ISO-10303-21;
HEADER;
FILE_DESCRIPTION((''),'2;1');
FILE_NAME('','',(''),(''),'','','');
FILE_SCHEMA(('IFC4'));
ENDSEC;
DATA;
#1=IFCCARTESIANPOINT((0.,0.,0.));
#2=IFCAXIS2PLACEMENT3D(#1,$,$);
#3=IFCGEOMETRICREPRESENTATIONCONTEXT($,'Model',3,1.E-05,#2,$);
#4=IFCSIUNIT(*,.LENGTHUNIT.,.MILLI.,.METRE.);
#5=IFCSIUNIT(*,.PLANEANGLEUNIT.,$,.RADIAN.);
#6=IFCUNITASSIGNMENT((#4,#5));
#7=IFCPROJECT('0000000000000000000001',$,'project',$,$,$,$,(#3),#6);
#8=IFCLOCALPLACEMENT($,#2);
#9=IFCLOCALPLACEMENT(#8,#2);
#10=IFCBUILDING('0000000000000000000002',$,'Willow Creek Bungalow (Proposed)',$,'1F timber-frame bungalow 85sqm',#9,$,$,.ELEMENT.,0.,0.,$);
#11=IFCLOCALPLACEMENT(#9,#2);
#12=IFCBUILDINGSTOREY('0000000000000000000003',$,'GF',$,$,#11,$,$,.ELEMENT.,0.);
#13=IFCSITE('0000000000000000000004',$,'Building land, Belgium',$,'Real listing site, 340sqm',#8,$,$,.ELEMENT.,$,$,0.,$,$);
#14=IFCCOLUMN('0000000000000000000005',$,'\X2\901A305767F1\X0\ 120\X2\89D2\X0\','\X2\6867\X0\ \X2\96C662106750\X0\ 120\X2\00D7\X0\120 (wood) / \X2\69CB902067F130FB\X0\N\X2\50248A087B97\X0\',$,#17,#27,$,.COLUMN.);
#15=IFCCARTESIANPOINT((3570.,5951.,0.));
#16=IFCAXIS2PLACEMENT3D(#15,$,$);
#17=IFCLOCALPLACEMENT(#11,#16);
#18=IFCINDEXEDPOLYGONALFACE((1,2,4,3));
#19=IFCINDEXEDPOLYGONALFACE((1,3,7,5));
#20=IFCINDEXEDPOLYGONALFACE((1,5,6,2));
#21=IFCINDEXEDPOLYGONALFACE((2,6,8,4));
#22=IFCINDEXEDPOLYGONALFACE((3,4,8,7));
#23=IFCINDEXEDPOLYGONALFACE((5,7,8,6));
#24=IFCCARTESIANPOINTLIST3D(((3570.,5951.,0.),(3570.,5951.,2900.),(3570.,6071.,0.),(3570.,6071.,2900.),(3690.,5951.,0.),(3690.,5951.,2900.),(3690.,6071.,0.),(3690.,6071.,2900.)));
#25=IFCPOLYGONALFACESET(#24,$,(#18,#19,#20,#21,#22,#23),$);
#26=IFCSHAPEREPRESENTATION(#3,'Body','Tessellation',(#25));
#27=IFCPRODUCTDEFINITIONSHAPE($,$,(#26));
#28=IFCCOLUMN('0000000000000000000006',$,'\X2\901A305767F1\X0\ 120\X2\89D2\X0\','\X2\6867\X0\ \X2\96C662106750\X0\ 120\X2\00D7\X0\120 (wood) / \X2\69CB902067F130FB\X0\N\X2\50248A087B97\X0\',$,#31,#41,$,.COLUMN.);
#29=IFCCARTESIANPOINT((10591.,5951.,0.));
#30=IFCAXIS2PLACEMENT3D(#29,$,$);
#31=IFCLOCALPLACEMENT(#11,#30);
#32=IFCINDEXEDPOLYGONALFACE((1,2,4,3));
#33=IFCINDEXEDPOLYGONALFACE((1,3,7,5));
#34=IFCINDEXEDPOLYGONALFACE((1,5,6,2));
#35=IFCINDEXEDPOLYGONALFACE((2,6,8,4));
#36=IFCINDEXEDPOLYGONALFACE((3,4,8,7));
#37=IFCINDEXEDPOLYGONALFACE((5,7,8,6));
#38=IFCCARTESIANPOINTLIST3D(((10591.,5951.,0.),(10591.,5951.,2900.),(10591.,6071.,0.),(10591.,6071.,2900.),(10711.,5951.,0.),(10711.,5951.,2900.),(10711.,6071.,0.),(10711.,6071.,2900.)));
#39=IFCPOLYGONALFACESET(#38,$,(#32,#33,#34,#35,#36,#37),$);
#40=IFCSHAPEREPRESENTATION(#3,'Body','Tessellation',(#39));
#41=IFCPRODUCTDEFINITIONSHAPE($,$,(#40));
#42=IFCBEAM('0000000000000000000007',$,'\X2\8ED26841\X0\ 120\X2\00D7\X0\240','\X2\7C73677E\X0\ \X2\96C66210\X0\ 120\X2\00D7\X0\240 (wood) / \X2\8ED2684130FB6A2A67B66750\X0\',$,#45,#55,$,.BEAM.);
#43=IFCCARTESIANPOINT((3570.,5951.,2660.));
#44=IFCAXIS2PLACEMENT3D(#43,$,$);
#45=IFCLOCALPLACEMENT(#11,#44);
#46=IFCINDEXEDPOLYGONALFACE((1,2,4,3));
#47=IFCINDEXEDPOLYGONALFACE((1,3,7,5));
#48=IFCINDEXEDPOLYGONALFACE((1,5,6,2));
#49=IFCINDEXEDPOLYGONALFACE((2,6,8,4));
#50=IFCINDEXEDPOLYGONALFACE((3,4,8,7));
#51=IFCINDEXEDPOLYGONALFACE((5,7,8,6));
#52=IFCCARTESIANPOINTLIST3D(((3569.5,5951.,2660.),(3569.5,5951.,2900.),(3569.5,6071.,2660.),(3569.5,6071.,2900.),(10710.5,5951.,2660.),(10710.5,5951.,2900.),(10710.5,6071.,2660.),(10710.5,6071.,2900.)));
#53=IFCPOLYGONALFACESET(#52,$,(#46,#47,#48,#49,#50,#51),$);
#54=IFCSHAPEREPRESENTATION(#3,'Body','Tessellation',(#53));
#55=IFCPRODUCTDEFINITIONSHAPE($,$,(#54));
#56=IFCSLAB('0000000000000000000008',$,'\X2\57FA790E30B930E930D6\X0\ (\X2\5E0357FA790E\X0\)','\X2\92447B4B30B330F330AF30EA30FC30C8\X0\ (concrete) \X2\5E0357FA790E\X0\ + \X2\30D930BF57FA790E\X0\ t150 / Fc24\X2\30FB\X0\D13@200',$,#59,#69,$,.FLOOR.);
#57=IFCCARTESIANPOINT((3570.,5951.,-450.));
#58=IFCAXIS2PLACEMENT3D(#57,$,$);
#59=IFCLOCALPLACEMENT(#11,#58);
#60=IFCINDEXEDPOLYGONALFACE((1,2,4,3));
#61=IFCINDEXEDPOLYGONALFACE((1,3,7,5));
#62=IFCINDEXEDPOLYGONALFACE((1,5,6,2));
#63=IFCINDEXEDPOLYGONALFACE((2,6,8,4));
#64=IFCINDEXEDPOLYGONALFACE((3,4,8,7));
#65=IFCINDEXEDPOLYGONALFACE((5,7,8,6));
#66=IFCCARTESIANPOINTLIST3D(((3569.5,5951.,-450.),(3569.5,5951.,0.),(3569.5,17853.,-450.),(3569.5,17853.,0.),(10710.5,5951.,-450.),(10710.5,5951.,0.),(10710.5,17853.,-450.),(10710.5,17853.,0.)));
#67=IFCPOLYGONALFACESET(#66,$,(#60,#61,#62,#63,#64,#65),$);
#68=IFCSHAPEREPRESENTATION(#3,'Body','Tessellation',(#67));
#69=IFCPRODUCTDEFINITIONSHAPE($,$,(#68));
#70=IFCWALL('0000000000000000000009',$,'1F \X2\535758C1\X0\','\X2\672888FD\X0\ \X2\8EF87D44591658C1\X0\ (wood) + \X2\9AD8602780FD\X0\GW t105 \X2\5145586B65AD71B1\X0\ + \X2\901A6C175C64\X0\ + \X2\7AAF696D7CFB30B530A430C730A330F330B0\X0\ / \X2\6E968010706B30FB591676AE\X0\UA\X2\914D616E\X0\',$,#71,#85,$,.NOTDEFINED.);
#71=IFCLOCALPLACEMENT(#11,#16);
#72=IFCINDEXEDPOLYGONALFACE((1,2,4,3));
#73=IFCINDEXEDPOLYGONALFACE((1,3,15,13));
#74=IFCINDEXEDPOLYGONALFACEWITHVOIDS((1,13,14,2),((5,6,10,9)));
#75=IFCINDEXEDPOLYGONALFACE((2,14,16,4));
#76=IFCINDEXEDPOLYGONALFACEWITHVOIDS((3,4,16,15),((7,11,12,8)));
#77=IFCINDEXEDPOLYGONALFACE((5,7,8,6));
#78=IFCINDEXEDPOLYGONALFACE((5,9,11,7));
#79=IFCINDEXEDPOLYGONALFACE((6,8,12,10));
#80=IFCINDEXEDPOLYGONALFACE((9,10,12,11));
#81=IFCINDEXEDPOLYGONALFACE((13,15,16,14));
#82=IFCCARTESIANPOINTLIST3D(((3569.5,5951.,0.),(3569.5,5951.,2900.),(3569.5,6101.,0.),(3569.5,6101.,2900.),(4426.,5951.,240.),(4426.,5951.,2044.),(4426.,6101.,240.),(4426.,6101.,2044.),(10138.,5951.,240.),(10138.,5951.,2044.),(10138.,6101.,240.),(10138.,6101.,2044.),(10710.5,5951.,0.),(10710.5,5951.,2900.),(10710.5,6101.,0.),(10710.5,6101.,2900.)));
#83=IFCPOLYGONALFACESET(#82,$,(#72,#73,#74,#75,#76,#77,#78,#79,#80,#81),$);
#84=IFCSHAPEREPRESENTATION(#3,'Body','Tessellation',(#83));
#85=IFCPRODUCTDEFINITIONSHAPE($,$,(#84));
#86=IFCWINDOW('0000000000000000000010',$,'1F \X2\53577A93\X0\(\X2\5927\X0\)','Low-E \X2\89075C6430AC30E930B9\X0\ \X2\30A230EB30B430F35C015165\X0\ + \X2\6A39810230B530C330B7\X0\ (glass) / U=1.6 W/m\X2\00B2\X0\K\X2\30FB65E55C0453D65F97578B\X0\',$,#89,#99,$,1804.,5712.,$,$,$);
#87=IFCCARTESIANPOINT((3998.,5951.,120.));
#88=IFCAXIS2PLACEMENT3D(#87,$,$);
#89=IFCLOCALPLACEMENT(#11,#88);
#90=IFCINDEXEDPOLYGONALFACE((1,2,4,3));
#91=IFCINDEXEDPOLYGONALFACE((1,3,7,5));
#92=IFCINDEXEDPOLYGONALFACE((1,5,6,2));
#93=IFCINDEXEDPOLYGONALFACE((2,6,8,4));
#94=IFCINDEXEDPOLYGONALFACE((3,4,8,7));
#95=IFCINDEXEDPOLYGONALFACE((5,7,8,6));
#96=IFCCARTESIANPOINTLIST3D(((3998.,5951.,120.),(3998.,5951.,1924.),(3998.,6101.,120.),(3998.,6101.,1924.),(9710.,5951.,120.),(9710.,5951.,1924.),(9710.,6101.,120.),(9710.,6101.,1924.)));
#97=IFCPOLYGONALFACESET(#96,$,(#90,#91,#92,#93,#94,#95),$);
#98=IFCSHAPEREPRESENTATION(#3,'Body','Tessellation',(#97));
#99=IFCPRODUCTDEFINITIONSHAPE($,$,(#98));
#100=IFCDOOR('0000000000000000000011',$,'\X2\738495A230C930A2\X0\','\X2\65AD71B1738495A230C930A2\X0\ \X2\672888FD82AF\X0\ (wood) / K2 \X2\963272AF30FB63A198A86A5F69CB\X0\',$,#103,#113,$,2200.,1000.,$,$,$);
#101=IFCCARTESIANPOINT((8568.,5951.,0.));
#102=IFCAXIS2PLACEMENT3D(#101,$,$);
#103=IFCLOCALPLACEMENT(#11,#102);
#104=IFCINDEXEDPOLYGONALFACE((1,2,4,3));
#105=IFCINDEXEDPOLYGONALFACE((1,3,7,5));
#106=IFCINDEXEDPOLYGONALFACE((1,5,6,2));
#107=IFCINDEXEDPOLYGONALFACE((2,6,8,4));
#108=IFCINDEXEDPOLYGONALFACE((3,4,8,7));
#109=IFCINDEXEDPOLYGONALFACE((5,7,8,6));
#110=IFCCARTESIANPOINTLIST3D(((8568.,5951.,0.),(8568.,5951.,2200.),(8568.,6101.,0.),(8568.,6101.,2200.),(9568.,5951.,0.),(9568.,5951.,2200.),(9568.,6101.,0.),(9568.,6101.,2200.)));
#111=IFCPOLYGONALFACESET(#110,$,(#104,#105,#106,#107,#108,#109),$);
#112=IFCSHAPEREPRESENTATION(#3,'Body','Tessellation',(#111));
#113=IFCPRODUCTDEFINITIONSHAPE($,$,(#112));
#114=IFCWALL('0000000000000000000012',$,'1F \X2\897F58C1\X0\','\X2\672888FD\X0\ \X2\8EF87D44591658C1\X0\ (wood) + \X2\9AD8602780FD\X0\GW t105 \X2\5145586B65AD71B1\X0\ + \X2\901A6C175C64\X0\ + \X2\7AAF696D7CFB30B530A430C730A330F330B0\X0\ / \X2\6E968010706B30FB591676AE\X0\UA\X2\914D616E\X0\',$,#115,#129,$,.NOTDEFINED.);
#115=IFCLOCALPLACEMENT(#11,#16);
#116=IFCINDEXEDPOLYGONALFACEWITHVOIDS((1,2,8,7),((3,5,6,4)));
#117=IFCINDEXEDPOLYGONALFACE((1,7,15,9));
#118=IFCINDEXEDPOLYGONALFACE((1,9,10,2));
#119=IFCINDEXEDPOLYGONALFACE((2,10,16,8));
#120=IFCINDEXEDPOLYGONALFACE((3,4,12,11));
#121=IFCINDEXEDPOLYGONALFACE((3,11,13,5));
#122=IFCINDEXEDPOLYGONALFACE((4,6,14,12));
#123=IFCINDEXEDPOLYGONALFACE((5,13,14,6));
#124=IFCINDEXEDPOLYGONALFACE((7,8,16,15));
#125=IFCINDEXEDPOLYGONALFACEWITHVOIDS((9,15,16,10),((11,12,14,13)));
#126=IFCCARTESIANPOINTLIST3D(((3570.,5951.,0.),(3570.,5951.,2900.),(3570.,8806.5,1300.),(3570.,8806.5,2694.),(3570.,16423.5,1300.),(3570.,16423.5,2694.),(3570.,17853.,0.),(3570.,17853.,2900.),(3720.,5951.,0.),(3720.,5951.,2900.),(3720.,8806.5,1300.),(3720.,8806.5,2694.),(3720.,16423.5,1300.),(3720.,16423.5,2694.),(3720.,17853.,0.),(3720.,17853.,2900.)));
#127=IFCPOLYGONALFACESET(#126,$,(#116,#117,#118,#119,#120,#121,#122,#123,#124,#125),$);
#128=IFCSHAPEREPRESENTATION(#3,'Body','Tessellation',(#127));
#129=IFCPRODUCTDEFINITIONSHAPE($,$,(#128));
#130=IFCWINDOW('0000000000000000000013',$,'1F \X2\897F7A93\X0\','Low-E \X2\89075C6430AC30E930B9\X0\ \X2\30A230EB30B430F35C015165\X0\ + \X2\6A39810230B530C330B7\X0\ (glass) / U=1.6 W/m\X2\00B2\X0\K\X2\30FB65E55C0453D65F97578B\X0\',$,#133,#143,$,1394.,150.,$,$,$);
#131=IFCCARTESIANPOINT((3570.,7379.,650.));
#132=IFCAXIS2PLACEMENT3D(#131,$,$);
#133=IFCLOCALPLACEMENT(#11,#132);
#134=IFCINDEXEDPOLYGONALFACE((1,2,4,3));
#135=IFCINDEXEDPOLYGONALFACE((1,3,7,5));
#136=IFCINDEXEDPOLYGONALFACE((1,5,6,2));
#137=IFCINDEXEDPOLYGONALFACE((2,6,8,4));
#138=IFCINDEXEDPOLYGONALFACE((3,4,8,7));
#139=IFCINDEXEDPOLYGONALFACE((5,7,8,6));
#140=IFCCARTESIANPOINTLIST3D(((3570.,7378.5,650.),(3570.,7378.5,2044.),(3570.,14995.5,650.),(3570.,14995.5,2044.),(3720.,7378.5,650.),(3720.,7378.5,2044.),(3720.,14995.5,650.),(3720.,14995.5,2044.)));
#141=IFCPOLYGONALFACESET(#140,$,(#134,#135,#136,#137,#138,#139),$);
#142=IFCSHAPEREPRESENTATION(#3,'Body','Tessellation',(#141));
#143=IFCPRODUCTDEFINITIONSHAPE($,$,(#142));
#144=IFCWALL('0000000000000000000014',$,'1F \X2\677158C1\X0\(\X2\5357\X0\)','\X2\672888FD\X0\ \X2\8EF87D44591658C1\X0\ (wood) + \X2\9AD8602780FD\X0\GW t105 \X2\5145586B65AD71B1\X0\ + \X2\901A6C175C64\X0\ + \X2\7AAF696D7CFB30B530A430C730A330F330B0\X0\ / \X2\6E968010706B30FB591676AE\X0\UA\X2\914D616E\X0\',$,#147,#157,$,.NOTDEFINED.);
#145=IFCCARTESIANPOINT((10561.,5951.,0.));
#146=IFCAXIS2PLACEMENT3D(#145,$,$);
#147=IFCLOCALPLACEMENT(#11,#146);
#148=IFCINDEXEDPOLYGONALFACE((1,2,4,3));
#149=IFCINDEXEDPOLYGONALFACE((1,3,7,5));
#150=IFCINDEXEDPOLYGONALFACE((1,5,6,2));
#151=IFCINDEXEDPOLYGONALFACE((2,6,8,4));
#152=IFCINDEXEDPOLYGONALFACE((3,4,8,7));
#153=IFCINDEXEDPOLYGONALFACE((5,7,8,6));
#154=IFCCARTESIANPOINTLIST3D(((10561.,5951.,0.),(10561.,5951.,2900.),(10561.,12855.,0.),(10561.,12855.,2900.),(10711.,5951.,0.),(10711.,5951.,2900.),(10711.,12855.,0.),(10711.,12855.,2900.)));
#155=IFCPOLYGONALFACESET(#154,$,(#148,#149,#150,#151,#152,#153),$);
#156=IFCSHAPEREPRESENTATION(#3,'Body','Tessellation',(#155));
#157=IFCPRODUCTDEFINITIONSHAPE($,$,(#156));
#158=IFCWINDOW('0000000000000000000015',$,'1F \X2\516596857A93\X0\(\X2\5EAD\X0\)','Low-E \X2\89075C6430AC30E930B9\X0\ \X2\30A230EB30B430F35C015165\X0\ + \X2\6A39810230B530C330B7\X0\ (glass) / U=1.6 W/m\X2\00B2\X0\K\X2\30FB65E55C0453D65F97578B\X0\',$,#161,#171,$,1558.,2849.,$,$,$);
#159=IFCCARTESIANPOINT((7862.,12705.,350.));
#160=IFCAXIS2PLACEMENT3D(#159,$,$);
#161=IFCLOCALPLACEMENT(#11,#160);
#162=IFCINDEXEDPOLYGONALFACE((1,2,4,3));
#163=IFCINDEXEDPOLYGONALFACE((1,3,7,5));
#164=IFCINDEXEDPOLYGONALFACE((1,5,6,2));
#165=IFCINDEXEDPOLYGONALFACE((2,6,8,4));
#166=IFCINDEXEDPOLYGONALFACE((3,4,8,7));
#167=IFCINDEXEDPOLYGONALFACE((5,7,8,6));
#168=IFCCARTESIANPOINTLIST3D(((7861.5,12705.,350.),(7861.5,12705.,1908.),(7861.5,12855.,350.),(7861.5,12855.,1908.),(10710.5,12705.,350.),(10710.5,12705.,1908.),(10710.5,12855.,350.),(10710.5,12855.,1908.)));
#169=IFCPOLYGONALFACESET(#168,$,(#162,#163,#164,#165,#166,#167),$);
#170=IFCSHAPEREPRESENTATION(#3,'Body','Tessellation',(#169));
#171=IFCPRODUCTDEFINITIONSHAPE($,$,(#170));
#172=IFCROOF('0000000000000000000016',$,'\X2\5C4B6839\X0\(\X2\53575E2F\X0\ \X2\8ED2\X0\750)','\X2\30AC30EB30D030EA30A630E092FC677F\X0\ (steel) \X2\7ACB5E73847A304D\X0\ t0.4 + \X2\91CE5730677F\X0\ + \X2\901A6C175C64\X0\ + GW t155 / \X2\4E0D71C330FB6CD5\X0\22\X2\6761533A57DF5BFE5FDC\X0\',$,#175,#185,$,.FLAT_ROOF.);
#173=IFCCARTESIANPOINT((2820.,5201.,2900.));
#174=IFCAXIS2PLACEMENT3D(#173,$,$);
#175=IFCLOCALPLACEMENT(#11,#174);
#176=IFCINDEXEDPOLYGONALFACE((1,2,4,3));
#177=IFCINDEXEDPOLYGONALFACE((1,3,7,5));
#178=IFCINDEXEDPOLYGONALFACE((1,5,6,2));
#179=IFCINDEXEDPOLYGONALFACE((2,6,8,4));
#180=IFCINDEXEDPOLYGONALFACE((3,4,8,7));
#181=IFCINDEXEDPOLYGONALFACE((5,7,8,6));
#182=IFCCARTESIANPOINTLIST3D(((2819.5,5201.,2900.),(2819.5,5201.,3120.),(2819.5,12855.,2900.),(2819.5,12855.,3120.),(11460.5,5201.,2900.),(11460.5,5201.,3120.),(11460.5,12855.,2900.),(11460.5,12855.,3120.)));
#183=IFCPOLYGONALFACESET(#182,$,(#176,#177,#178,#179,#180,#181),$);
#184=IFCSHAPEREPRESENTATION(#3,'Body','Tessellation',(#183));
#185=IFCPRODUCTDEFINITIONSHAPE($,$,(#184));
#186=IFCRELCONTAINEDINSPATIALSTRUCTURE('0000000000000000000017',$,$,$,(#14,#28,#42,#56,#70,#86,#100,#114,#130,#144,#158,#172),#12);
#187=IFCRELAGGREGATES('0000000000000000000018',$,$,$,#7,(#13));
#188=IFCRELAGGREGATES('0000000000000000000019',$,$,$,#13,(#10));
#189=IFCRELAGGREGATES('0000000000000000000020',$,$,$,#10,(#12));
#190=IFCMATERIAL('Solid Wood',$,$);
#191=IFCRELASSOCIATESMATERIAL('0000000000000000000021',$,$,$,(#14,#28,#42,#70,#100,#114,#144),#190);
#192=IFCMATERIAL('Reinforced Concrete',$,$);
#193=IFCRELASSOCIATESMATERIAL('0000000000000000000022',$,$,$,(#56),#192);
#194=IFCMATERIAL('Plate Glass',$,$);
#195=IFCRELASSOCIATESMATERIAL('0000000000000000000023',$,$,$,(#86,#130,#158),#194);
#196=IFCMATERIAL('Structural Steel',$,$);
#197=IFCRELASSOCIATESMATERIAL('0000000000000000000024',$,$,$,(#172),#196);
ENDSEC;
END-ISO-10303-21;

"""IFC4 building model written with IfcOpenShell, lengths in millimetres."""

from ifc_helpers import new_model, si_unit, frame, frame_2d, origin, place, context, project, spatial, rectangle, extrude, material, element, fill, save


model = new_model("IFC4")

# Units and contexts
model_context = context("Model", 3, precision=1e-05, world=origin())
ifc_project = project(units=[si_unit("LENGTHUNIT", "METRE", prefix="MILLI"), si_unit("PLANEANGLEUNIT", "RADIAN")], contexts=[model_context])

# Site, building, storey
site_placement = place(None, origin())
site = spatial("IfcSite", under=ifc_project, at=site_placement, Name="Building land, Belgium", ObjectType="Real listing site, 340sqm", CompositionType="ELEMENT", RefElevation=0.0)
building_placement = place(site_placement, origin())
building = spatial("IfcBuilding", under=site, at=building_placement, Name="Willow Creek Bungalow (Proposed)", ObjectType="1F timber-frame bungalow 85sqm", CompositionType="ELEMENT", ElevationOfRefHeight=0.0, ElevationOfTerrain=0.0)
storey_placement = place(building_placement, origin())
storey = spatial("IfcBuildingStorey", under=building, at=storey_placement, Name="GF", CompositionType="ELEMENT", Elevation=0.0)

# Columns
ifc_material_1 = material(Name="Solid Wood")
column_1_placement = place(storey_placement, frame((3570.0, 5951.0, 0.0)))
element("IfcColumn", 1, at=column_1_placement, inside=storey, material=ifc_material_1, Name="通し柱 120角", Description="桧 集成材 120×120 (wood) / 構造柱・N値計算", PredefinedType="COLUMN", context=model_context, shape_type="SweptSolid", body=[
    extrude(rectangle(XDim=120.0, YDim=120.0, at=frame_2d((60.0, 60.0))), frame((3570.0, 5951.0, 0.0)), (0.0, 0.0, 1.0), 2900.0),
])
column_2_placement = place(storey_placement, frame((10591.0, 5951.0, 0.0)))
element("IfcColumn", 2, at=column_2_placement, inside=storey, material=ifc_material_1, Name="通し柱 120角", Description="桧 集成材 120×120 (wood) / 構造柱・N値計算", PredefinedType="COLUMN", context=model_context, shape_type="SweptSolid", body=[
    extrude(rectangle(XDim=120.0, YDim=120.0, at=frame_2d((60.0, 60.0))), frame((10591.0, 5951.0, 0.0)), (0.0, 0.0, 1.0), 2900.0),
])

# Beam
beam_1_placement = place(storey_placement, frame((3570.0, 5951.0, 2660.0)))
element("IfcBeam", 3, at=beam_1_placement, inside=storey, material=ifc_material_1, Name="軒桁 120×240", Description="米松 集成 120×240 (wood) / 軒桁・横架材", PredefinedType="BEAM", context=model_context, shape_type="SweptSolid", body=[
    extrude(rectangle(XDim=7141.0, YDim=120.0, at=frame_2d((3570.0, 60.0))), frame((3570.0, 5951.0, 2660.0)), (0.0, 0.0, 1.0), 240.0),
])

# Slab
ifc_material_2 = material(Name="Reinforced Concrete")
slab_1_placement = place(storey_placement, frame((3570.0, 5951.0, -450.0)))
element("IfcSlab", 4, at=slab_1_placement, inside=storey, material=ifc_material_2, Name="基礎スラブ (布基礎)", Description="鉄筋コンクリート (concrete) 布基礎 + ベタ基礎 t150 / Fc24・D13@200", PredefinedType="FLOOR", context=model_context, shape_type="SweptSolid", body=[
    extrude(rectangle(XDim=7141.0, YDim=11902.0, at=frame_2d((3570.0, 5951.0))), frame((3570.0, 5951.0, -450.0)), (0.0, 0.0, 1.0), 450.0),
])

# Wall, openings, window, door
wall_1_placement = place(storey_placement, frame((3570.0, 5951.0, 0.0)))
wall_1 = element("IfcWall", 5, at=wall_1_placement, inside=storey, material=ifc_material_1, Name="1F 南壁", Description="木製 軸組外壁 (wood) + 高性能GW t105 充填断熱 + 通気層 + 窯業系サイディング / 準耐火・外皮UA配慮", PredefinedType="NOTDEFINED", context=model_context, shape_type="SweptSolid", body=[
    extrude(rectangle(XDim=7141.0, YDim=150.0, at=frame_2d((3570.0, 75.0))), frame((3570.0, 5951.0, 0.0)), (0.0, 0.0, 1.0), 2900.0),
])
opening_1_placement = place(storey_placement, frame((3998.0, 5951.0, 120.0)))
opening_1 = element("IfcOpeningElement", 6, at=opening_1_placement, cuts=wall_1, PredefinedType="NOTDEFINED", context=model_context, shape_type="SweptSolid", body=[
    extrude(rectangle(XDim=5712.0, YDim=150.0, at=frame_2d((2856.0, 75.0))), frame((3998.0, 5951.0, 120.0)), (0.0, 0.0, 1.0), 1804.0),
])
opening_2_placement = place(storey_placement, frame((8568.0, 5951.0, 0.0)))
opening_2 = element("IfcOpeningElement", 7, at=opening_2_placement, cuts=wall_1, PredefinedType="NOTDEFINED", context=model_context, shape_type="SweptSolid", body=[
    extrude(rectangle(XDim=1000.0, YDim=150.0, at=frame_2d((500.0, 75.0))), frame((8568.0, 5951.0, 0.0)), (0.0, 0.0, 1.0), 2200.0),
])
ifc_material_3 = material(Name="Plate Glass")
window_1_placement = place(storey_placement, frame((3998.0, 5951.0, 120.0)))
window_1 = element("IfcWindow", 8, at=window_1_placement, inside=storey, material=ifc_material_3, Name="1F 南窓(大)", Description="Low-E 複層ガラス アルゴン封入 + 樹脂サッシ (glass) / U=1.6 W/m²K・日射取得型", OverallHeight=1804.0, OverallWidth=5712.0, context=model_context, shape_type="SweptSolid", body=[
    extrude(rectangle(XDim=5712.0, YDim=150.0, at=frame_2d((2856.0, 75.0))), frame((3998.0, 5951.0, 120.0)), (0.0, 0.0, 1.0), 1804.0),
])
fill(opening_1, window_1)
door_1_placement = place(storey_placement, frame((8568.0, 5951.0, 0.0)))
door_1 = element("IfcDoor", 9, at=door_1_placement, inside=storey, material=ifc_material_1, Name="玄関ドア", Description="断熱玄関ドア 木製芯 (wood) / K2 防犯・採風機構", OverallHeight=2200.0, OverallWidth=1000.0, context=model_context, shape_type="SweptSolid", body=[
    extrude(rectangle(XDim=1000.0, YDim=150.0, at=frame_2d((500.0, 75.0))), frame((8568.0, 5951.0, 0.0)), (0.0, 0.0, 1.0), 2200.0),
])
fill(opening_2, door_1)

# Walls, openings, windows
wall_2_placement = place(storey_placement, frame((3570.0, 5951.0, 0.0)))
wall_2 = element("IfcWall", 10, at=wall_2_placement, inside=storey, material=ifc_material_1, Name="1F 西壁", Description="木製 軸組外壁 (wood) + 高性能GW t105 充填断熱 + 通気層 + 窯業系サイディング / 準耐火・外皮UA配慮", PredefinedType="NOTDEFINED", context=model_context, shape_type="SweptSolid", body=[
    extrude(rectangle(XDim=150.0, YDim=11902.0, at=frame_2d((75.0, 5951.0))), frame((3570.0, 5951.0, 0.0)), (0.0, 0.0, 1.0), 2900.0),
])
opening_3_placement = place(storey_placement, frame((3570.0, 7379.0, 650.0)))
opening_3 = element("IfcOpeningElement", 11, at=opening_3_placement, cuts=wall_2, PredefinedType="NOTDEFINED", context=model_context, shape_type="SweptSolid", body=[
    extrude(rectangle(XDim=150.0, YDim=7617.0, at=frame_2d((75.0, 3808.0))), frame((3570.0, 7379.0, 650.0)), (0.0, 0.0, 1.0), 1394.0),
])
window_2_placement = place(storey_placement, frame((3570.0, 7379.0, 650.0)))
window_2 = element("IfcWindow", 12, at=window_2_placement, inside=storey, material=ifc_material_3, Name="1F 西窓", Description="Low-E 複層ガラス アルゴン封入 + 樹脂サッシ (glass) / U=1.6 W/m²K・日射取得型", OverallHeight=1394.0, OverallWidth=150.0, context=model_context, shape_type="SweptSolid", body=[
    extrude(rectangle(XDim=150.0, YDim=7617.0, at=frame_2d((75.0, 3808.0))), frame((3570.0, 7379.0, 650.0)), (0.0, 0.0, 1.0), 1394.0),
])
fill(opening_3, window_2)
wall_3_placement = place(storey_placement, frame((10561.0, 5951.0, 0.0)))
wall_3 = element("IfcWall", 13, at=wall_3_placement, inside=storey, material=ifc_material_1, Name="1F 東壁(南)", Description="木製 軸組外壁 (wood) + 高性能GW t105 充填断熱 + 通気層 + 窯業系サイディング / 準耐火・外皮UA配慮", PredefinedType="NOTDEFINED", context=model_context, shape_type="SweptSolid", body=[
    extrude(rectangle(XDim=150.0, YDim=6904.0, at=frame_2d((75.0, 3452.0))), frame((10561.0, 5951.0, 0.0)), (0.0, 0.0, 1.0), 2900.0),
])
opening_4_placement = place(storey_placement, frame((7862.0, 12705.0, 350.0)))
opening_4 = element("IfcOpeningElement", 14, at=opening_4_placement, cuts=wall_3, PredefinedType="NOTDEFINED", context=model_context, shape_type="SweptSolid", body=[
    extrude(rectangle(XDim=2849.0, YDim=150.0, at=frame_2d((1424.0, 75.0))), frame((7862.0, 12705.0, 350.0)), (0.0, 0.0, 1.0), 1558.0),
])
window_3_placement = place(storey_placement, frame((7862.0, 12705.0, 350.0)))
window_3 = element("IfcWindow", 15, at=window_3_placement, inside=storey, material=ifc_material_3, Name="1F 入隅窓(庭)", Description="Low-E 複層ガラス アルゴン封入 + 樹脂サッシ (glass) / U=1.6 W/m²K・日射取得型", OverallHeight=1558.0, OverallWidth=2849.0, context=model_context, shape_type="SweptSolid", body=[
    extrude(rectangle(XDim=2849.0, YDim=150.0, at=frame_2d((1424.0, 75.0))), frame((7862.0, 12705.0, 350.0)), (0.0, 0.0, 1.0), 1558.0),
])
fill(opening_4, window_3)

# Roof
ifc_material_4 = material(Name="Structural Steel")
roof_placement = place(storey_placement, frame((2820.0, 5201.0, 2900.0)))
element("IfcRoof", 16, at=roof_placement, inside=storey, material=ifc_material_4, Name="屋根(南帯 軒750)", Description="ガルバリウム鋼板 (steel) 立平葺き t0.4 + 野地板 + 通気層 + GW t155 / 不燃・法22条区域対応", PredefinedType="FLAT_ROOF", context=model_context, shape_type="SweptSolid", body=[
    extrude(rectangle(XDim=8641.0, YDim=7654.0, at=frame_2d((4320.0, 3827.0))), frame((2820.0, 5201.0, 2900.0)), (0.0, 0.0, 1.0), 220.0),
])

save(model, "model.ifc")
